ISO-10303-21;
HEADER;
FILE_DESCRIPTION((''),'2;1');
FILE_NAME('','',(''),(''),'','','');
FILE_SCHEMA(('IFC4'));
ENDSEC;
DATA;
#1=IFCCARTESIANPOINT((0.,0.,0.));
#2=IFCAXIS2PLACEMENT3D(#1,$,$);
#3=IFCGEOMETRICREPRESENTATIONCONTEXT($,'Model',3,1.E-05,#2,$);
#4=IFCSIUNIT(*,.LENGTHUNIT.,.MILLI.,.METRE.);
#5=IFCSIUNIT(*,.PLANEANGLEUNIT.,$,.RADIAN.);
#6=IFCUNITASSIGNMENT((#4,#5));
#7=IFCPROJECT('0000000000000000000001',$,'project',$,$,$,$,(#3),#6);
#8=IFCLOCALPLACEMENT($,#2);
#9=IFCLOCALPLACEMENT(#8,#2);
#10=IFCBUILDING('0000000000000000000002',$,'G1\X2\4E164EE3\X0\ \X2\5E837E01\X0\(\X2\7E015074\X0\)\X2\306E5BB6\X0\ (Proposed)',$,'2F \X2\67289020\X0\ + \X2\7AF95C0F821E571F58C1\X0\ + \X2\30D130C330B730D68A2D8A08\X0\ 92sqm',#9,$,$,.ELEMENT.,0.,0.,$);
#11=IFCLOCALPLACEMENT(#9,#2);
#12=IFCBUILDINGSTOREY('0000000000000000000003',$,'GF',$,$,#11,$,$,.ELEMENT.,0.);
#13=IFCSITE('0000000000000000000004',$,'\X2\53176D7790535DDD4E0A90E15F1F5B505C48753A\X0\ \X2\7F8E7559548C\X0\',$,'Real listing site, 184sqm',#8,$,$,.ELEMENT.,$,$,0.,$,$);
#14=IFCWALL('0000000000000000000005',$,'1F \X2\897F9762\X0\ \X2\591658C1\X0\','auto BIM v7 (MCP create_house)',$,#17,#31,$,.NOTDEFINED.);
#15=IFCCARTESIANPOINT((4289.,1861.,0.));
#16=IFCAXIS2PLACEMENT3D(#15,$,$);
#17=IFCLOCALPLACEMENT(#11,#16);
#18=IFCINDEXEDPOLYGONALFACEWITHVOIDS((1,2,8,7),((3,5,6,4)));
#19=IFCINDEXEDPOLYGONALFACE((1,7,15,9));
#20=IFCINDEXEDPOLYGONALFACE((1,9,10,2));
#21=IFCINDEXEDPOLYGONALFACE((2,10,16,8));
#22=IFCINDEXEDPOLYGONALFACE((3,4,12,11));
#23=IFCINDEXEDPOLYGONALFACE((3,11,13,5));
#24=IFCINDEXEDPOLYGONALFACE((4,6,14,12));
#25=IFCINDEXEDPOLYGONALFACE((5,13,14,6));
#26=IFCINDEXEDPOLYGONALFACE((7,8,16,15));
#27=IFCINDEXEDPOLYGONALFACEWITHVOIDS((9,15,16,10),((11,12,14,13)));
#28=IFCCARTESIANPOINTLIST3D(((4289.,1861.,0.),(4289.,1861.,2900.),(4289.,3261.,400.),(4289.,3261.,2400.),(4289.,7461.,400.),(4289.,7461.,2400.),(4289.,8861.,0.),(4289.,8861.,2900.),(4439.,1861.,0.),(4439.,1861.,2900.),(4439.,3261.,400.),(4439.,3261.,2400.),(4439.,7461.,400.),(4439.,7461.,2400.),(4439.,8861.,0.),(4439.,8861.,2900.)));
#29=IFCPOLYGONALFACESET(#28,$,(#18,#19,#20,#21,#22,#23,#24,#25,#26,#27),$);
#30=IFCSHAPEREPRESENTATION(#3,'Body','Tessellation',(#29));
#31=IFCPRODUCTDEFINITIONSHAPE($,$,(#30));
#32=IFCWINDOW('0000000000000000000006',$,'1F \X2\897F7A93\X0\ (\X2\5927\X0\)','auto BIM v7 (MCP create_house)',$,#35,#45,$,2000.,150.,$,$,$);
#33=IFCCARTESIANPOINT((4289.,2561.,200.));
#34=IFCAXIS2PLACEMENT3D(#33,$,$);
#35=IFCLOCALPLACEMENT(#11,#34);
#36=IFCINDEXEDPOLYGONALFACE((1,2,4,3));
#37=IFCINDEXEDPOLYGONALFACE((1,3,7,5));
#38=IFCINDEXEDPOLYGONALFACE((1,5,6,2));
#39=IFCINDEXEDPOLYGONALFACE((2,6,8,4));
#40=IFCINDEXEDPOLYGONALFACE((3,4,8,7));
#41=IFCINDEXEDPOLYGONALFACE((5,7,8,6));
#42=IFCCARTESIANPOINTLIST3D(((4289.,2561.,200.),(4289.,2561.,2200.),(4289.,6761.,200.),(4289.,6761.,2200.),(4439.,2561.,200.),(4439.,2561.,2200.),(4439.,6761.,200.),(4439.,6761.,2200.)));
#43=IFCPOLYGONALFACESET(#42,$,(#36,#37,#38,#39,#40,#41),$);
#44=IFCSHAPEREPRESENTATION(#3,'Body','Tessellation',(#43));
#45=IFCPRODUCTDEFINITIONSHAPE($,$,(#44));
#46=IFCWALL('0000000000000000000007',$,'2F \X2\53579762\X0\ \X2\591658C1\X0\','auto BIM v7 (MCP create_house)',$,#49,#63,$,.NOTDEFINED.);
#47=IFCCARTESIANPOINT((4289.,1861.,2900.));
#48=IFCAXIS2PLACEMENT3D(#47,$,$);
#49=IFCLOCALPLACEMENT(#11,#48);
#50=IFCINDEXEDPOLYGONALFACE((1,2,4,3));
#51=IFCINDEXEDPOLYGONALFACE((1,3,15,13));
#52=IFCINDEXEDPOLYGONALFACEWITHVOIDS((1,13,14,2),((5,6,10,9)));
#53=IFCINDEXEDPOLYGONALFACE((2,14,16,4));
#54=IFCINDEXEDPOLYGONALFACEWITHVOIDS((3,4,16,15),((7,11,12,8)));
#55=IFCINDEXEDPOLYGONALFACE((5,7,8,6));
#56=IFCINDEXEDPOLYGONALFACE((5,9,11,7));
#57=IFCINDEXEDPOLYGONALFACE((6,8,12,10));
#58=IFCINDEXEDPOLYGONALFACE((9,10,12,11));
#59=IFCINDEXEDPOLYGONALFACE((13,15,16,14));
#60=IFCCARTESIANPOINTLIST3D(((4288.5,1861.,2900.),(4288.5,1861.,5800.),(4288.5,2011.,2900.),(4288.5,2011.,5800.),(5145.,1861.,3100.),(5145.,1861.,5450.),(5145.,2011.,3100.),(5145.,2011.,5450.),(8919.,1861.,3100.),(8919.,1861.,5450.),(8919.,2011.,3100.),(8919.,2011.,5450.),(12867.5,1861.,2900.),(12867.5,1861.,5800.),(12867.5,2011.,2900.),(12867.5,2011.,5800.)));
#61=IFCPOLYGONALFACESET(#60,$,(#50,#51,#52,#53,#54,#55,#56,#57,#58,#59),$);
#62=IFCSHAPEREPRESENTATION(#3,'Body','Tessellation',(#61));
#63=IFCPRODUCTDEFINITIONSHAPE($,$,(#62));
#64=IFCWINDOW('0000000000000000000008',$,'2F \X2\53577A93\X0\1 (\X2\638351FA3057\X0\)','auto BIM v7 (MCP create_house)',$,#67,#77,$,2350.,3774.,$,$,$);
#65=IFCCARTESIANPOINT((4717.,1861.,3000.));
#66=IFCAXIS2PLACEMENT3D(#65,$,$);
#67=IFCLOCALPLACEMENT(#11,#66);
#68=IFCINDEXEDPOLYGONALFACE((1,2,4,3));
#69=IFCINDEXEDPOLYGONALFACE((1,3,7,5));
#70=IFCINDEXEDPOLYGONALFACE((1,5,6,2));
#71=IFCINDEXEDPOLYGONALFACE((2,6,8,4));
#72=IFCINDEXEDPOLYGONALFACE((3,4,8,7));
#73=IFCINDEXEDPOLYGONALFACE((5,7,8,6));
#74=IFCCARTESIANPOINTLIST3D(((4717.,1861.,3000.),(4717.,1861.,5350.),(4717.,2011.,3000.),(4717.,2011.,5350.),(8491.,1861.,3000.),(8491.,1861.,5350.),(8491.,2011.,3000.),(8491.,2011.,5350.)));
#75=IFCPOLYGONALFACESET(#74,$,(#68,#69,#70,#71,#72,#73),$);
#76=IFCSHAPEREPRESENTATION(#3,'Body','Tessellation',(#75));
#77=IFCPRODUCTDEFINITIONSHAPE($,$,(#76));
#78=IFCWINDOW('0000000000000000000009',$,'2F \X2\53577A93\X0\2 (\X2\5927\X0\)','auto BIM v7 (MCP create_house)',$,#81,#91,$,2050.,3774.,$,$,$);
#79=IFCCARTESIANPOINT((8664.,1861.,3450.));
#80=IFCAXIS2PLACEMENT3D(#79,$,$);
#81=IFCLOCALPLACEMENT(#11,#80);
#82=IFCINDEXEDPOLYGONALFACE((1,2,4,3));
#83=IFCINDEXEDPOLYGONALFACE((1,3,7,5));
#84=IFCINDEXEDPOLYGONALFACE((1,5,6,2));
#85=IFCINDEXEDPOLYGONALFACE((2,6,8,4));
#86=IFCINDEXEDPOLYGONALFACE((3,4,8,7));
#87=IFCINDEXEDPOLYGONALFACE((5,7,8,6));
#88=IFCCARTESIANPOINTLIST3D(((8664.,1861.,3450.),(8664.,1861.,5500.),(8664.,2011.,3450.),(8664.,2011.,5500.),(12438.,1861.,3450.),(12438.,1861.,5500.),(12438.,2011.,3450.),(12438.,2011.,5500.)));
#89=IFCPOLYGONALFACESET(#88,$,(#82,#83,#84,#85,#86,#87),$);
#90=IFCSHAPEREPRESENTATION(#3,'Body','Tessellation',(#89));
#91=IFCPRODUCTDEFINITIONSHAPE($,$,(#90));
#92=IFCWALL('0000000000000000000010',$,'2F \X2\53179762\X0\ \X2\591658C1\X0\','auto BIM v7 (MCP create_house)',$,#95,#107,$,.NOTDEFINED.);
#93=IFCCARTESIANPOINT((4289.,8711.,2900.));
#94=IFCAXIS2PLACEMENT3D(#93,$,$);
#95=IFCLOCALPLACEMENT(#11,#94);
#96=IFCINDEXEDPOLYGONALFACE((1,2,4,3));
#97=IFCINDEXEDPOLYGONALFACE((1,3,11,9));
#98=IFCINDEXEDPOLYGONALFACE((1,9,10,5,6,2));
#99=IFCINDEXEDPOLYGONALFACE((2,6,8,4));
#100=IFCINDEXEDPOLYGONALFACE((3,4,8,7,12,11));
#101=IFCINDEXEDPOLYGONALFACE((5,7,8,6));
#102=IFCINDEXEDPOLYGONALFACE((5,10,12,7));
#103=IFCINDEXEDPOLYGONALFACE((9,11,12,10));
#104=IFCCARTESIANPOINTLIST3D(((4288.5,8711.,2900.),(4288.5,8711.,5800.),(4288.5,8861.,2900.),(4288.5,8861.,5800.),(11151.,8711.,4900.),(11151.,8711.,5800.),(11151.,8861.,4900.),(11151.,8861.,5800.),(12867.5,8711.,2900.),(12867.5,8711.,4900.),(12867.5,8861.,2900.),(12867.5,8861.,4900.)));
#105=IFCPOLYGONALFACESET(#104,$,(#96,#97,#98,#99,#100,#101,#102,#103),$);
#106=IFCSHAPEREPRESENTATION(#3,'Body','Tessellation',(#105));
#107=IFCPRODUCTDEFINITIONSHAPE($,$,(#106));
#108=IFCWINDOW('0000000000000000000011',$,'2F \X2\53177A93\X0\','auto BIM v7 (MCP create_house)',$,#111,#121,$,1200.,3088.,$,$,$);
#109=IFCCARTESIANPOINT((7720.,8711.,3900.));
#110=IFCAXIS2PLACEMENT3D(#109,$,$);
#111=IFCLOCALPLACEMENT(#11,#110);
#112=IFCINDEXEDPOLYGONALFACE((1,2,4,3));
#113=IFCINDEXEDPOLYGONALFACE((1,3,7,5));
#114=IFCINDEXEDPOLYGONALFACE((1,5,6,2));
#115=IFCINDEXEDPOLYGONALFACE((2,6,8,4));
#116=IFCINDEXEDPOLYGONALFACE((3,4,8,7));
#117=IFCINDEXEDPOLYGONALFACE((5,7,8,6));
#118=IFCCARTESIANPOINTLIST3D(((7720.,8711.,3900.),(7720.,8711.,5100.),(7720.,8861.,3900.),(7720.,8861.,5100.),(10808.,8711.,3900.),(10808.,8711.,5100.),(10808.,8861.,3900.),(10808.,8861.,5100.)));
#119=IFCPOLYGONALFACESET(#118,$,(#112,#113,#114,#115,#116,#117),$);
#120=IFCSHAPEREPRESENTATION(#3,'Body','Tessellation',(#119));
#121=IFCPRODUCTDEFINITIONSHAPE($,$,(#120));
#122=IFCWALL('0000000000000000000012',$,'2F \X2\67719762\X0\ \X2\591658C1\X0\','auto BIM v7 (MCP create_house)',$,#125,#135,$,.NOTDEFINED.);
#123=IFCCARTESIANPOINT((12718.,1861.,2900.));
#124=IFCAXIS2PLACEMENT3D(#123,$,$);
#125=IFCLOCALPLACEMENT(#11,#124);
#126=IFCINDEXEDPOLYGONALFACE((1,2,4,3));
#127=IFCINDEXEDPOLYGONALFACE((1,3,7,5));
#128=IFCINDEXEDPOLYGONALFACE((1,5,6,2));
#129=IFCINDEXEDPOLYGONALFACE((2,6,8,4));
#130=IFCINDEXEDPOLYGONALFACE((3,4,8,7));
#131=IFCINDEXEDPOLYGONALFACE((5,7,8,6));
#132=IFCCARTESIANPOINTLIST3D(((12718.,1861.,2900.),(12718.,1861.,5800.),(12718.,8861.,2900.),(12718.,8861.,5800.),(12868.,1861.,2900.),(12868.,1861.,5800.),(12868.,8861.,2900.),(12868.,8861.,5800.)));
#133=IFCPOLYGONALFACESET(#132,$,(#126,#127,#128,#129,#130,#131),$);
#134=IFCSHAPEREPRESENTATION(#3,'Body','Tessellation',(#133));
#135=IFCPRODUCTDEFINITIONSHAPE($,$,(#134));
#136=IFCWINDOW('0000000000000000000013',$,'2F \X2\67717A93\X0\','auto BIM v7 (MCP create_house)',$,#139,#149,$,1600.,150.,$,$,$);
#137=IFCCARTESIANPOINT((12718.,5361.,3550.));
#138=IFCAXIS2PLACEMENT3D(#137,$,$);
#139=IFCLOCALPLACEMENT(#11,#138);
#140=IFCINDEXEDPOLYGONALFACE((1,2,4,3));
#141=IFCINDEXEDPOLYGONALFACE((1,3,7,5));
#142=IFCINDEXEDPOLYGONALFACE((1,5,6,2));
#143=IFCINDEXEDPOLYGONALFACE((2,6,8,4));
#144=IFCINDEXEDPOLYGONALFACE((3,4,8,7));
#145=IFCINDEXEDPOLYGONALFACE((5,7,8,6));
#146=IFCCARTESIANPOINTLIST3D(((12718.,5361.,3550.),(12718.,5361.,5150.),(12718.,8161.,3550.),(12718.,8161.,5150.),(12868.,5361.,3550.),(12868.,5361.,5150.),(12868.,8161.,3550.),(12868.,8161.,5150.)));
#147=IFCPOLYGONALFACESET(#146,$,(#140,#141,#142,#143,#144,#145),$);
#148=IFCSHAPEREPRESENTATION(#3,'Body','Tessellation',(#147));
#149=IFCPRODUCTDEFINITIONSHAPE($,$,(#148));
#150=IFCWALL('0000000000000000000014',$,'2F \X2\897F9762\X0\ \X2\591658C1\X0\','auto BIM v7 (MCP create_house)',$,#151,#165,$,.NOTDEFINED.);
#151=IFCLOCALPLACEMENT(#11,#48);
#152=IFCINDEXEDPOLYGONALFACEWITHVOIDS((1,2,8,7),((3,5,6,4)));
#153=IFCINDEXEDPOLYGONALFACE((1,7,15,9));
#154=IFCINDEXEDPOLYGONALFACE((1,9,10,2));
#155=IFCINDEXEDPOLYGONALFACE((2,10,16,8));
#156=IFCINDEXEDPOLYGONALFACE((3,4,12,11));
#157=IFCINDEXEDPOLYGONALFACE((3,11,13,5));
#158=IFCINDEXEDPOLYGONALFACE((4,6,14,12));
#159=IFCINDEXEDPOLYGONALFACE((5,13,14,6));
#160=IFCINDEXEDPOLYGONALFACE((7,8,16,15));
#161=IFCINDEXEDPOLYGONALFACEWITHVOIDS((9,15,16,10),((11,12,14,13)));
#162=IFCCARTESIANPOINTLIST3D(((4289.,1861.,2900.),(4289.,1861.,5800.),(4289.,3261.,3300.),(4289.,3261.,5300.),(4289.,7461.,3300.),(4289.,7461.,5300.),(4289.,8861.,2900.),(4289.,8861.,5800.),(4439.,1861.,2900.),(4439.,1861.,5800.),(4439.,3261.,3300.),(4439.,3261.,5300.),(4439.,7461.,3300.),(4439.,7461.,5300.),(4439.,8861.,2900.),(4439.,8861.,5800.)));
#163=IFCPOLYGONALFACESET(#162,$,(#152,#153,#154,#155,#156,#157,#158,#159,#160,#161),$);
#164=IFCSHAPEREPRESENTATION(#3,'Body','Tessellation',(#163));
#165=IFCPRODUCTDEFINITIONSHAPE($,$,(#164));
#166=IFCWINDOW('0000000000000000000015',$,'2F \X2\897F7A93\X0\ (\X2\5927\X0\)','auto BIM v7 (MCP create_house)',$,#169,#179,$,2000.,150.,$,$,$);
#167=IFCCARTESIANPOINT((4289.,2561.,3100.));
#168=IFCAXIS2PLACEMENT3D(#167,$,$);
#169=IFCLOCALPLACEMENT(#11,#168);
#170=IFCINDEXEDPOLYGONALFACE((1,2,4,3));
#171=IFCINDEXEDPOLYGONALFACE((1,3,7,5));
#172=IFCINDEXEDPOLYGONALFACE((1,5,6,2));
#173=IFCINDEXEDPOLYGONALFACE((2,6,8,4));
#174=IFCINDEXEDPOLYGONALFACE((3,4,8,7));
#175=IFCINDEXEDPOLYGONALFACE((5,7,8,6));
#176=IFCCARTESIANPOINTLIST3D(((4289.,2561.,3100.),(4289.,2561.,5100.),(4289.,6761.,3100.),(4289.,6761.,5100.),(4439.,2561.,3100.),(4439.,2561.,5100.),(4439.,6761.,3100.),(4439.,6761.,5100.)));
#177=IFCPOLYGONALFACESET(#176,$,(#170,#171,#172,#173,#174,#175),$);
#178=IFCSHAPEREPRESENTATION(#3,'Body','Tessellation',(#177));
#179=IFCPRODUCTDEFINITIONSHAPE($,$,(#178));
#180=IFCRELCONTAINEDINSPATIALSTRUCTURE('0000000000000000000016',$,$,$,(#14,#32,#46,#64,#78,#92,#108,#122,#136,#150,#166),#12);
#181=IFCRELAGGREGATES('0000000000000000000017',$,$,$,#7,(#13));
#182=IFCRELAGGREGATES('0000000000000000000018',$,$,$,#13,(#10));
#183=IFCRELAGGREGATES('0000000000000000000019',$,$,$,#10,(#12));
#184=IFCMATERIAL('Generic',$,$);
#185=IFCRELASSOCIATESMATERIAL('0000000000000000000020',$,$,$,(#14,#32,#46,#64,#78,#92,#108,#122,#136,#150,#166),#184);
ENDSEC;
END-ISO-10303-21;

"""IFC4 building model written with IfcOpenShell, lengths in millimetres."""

from ifc_helpers import new_model, si_unit, frame, frame_2d, origin, place, context, project, spatial, rectangle, extrude, material, element, fill, save


model = new_model("IFC4")

# Units and contexts
model_context = context("Model", 3, precision=1e-05, world=origin())
ifc_project = project(units=[si_unit("LENGTHUNIT", "METRE", prefix="MILLI"), si_unit("PLANEANGLEUNIT", "RADIAN")], contexts=[model_context])

# Site, building, storey
site_placement = place(None, origin())
site = spatial("IfcSite", under=ifc_project, at=site_placement, Name="北海道川上郡弟子屈町 美留和", ObjectType="Real listing site, 184sqm", CompositionType="ELEMENT", RefElevation=0.0)
building_placement = place(site_placement, origin())
building = spatial("IfcBuilding", under=site, at=building_placement, Name="G1世代 広縁(縁側)の家 (Proposed)", ObjectType="2F 木造 + 竹小舞土壁 + パッシブ設計 92sqm", CompositionType="ELEMENT", ElevationOfRefHeight=0.0, ElevationOfTerrain=0.0)
storey_placement = place(building_placement, origin())
storey = spatial("IfcBuildingStorey", under=building, at=storey_placement, Name="GF", CompositionType="ELEMENT", Elevation=0.0)

# Shared definitions
ifc_material = material(Name="Generic")

# Wall, opening, window
wall_1_placement = place(storey_placement, frame((4289.0, 1861.0, 0.0)))
wall_1 = element("IfcWall", 1, at=wall_1_placement, inside=storey, material=ifc_material, Name="1F 西面 外壁", Description="auto BIM v7 (MCP create_house)", PredefinedType="NOTDEFINED", context=model_context, shape_type="SweptSolid", body=[
    extrude(rectangle(XDim=150.0, YDim=7000.0, at=frame_2d((75.0, 3500.0))), frame((4289.0, 1861.0, 0.0)), (0.0, 0.0, 1.0), 2900.0),
])
opening_1_placement = place(storey_placement, frame((4289.0, 2561.0, 200.0)))
opening_1 = element("IfcOpeningElement", 2, at=opening_1_placement, cuts=wall_1, PredefinedType="NOTDEFINED", context=model_context, shape_type="SweptSolid", body=[
    extrude(rectangle(XDim=150.0, YDim=4200.0, at=frame_2d((75.0, 2100.0))), frame((4289.0, 2561.0, 200.0)), (0.0, 0.0, 1.0), 2000.0),
])
window_1_placement = place(storey_placement, frame((4289.0, 2561.0, 200.0)))
window_1 = element("IfcWindow", 3, at=window_1_placement, inside=storey, material=ifc_material, Name="1F 西窓 (大)", Description="auto BIM v7 (MCP create_house)", OverallHeight=2000.0, OverallWidth=150.0, context=model_context, shape_type="SweptSolid", body=[
    extrude(rectangle(XDim=150.0, YDim=4200.0, at=frame_2d((75.0, 2100.0))), frame((4289.0, 2561.0, 200.0)), (0.0, 0.0, 1.0), 2000.0),
])
fill(opening_1, window_1)

# Wall, openings, windows
wall_2_placement = place(storey_placement, frame((4289.0, 1861.0, 2900.0)))
wall_2 = element("IfcWall", 4, at=wall_2_placement, inside=storey, material=ifc_material, Name="2F 南面 外壁", Description="auto BIM v7 (MCP create_house)", PredefinedType="NOTDEFINED", context=model_context, shape_type="SweptSolid", body=[
    extrude(rectangle(XDim=8579.0, YDim=150.0, at=frame_2d((4289.0, 75.0))), frame((4289.0, 1861.0, 2900.0)), (0.0, 0.0, 1.0), 2900.0),
])
opening_2_placement = place(storey_placement, frame((4717.0, 1861.0, 3000.0)))
opening_2 = element("IfcOpeningElement", 5, at=opening_2_placement, cuts=wall_2, PredefinedType="NOTDEFINED", context=model_context, shape_type="SweptSolid", body=[
    extrude(rectangle(XDim=3774.0, YDim=150.0, at=frame_2d((1887.0, 75.0))), frame((4717.0, 1861.0, 3000.0)), (0.0, 0.0, 1.0), 2350.0),
])
opening_3_placement = place(storey_placement, frame((8664.0, 1861.0, 3450.0)))
opening_3 = element("IfcOpeningElement", 6, at=opening_3_placement, cuts=wall_2, PredefinedType="NOTDEFINED", context=model_context, shape_type="SweptSolid", body=[
    extrude(rectangle(XDim=3774.0, YDim=150.0, at=frame_2d((1887.0, 75.0))), frame((8664.0, 1861.0, 3450.0)), (0.0, 0.0, 1.0), 2050.0),
])
window_2_placement = place(storey_placement, frame((4717.0, 1861.0, 3000.0)))
window_2 = element("IfcWindow", 7, at=window_2_placement, inside=storey, material=ifc_material, Name="2F 南窓1 (掃出し)", Description="auto BIM v7 (MCP create_house)", OverallHeight=2350.0, OverallWidth=3774.0, context=model_context, shape_type="SweptSolid", body=[
    extrude(rectangle(XDim=3774.0, YDim=150.0, at=frame_2d((1887.0, 75.0))), frame((4717.0, 1861.0, 3000.0)), (0.0, 0.0, 1.0), 2350.0),
])
fill(opening_2, window_2)
window_3_placement = place(storey_placement, frame((8664.0, 1861.0, 3450.0)))
window_3 = element("IfcWindow", 8, at=window_3_placement, inside=storey, material=ifc_material, Name="2F 南窓2 (大)", Description="auto BIM v7 (MCP create_house)", OverallHeight=2050.0, OverallWidth=3774.0, context=model_context, shape_type="SweptSolid", body=[
    extrude(rectangle(XDim=3774.0, YDim=150.0, at=frame_2d((1887.0, 75.0))), frame((8664.0, 1861.0, 3450.0)), (0.0, 0.0, 1.0), 2050.0),
])
fill(opening_3, window_3)

# Walls, openings, windows
wall_3_placement = place(storey_placement, frame((4289.0, 8711.0, 2900.0)))
wall_3 = element("IfcWall", 9, at=wall_3_placement, inside=storey, material=ifc_material, Name="2F 北面 外壁", Description="auto BIM v7 (MCP create_house)", PredefinedType="NOTDEFINED", context=model_context, shape_type="SweptSolid", body=[
    extrude(rectangle(XDim=8579.0, YDim=150.0, at=frame_2d((4289.0, 75.0))), frame((4289.0, 8711.0, 2900.0)), (0.0, 0.0, 1.0), 2900.0),
])
opening_4_placement = place(storey_placement, frame((7720.0, 8711.0, 3900.0)))
opening_4 = element("IfcOpeningElement", 10, at=opening_4_placement, cuts=wall_3, PredefinedType="NOTDEFINED", context=model_context, shape_type="SweptSolid", body=[
    extrude(rectangle(XDim=3088.0, YDim=150.0, at=frame_2d((1544.0, 75.0))), frame((7720.0, 8711.0, 3900.0)), (0.0, 0.0, 1.0), 1200.0),
])
window_4_placement = place(storey_placement, frame((7720.0, 8711.0, 3900.0)))
window_4 = element("IfcWindow", 11, at=window_4_placement, inside=storey, material=ifc_material, Name="2F 北窓", Description="auto BIM v7 (MCP create_house)", OverallHeight=1200.0, OverallWidth=3088.0, context=model_context, shape_type="SweptSolid", body=[
    extrude(rectangle(XDim=3088.0, YDim=150.0, at=frame_2d((1544.0, 75.0))), frame((7720.0, 8711.0, 3900.0)), (0.0, 0.0, 1.0), 1200.0),
])
fill(opening_4, window_4)
wall_4_placement = place(storey_placement, frame((12718.0, 1861.0, 2900.0)))
wall_4 = element("IfcWall", 12, at=wall_4_placement, inside=storey, material=ifc_material, Name="2F 東面 外壁", Description="auto BIM v7 (MCP create_house)", PredefinedType="NOTDEFINED", context=model_context, shape_type="SweptSolid", body=[
    extrude(rectangle(XDim=150.0, YDim=7000.0, at=frame_2d((75.0, 3500.0))), frame((12718.0, 1861.0, 2900.0)), (0.0, 0.0, 1.0), 2900.0),
])
opening_5_placement = place(storey_placement, frame((12718.0, 5361.0, 3550.0)))
opening_5 = element("IfcOpeningElement", 13, at=opening_5_placement, cuts=wall_4, PredefinedType="NOTDEFINED", context=model_context, shape_type="SweptSolid", body=[
    extrude(rectangle(XDim=150.0, YDim=2800.0, at=frame_2d((75.0, 1400.0))), frame((12718.0, 5361.0, 3550.0)), (0.0, 0.0, 1.0), 1600.0),
])
window_5_placement = place(storey_placement, frame((12718.0, 5361.0, 3550.0)))
window_5 = element("IfcWindow", 14, at=window_5_placement, inside=storey, material=ifc_material, Name="2F 東窓", Description="auto BIM v7 (MCP create_house)", OverallHeight=1600.0, OverallWidth=150.0, context=model_context, shape_type="SweptSolid", body=[
    extrude(rectangle(XDim=150.0, YDim=2800.0, at=frame_2d((75.0, 1400.0))), frame((12718.0, 5361.0, 3550.0)), (0.0, 0.0, 1.0), 1600.0),
])
fill(opening_5, window_5)
wall_5_placement = place(storey_placement, frame((4289.0, 1861.0, 2900.0)))
wall_5 = element("IfcWall", 15, at=wall_5_placement, inside=storey, material=ifc_material, Name="2F 西面 外壁", Description="auto BIM v7 (MCP create_house)", PredefinedType="NOTDEFINED", context=model_context, shape_type="SweptSolid", body=[
    extrude(rectangle(XDim=150.0, YDim=7000.0, at=frame_2d((75.0, 3500.0))), frame((4289.0, 1861.0, 2900.0)), (0.0, 0.0, 1.0), 2900.0),
])
opening_6_placement = place(storey_placement, frame((4289.0, 2561.0, 3100.0)))
opening_6 = element("IfcOpeningElement", 16, at=opening_6_placement, cuts=wall_5, PredefinedType="NOTDEFINED", context=model_context, shape_type="SweptSolid", body=[
    extrude(rectangle(XDim=150.0, YDim=4200.0, at=frame_2d((75.0, 2100.0))), frame((4289.0, 2561.0, 3100.0)), (0.0, 0.0, 1.0), 2000.0),
])
window_6_placement = place(storey_placement, frame((4289.0, 2561.0, 3100.0)))
window_6 = element("IfcWindow", 17, at=window_6_placement, inside=storey, material=ifc_material, Name="2F 西窓 (大)", Description="auto BIM v7 (MCP create_house)", OverallHeight=2000.0, OverallWidth=150.0, context=model_context, shape_type="SweptSolid", body=[
    extrude(rectangle(XDim=150.0, YDim=4200.0, at=frame_2d((75.0, 2100.0))), frame((4289.0, 2561.0, 3100.0)), (0.0, 0.0, 1.0), 2000.0),
])
fill(opening_6, window_6)

save(model, "model.ifc")
